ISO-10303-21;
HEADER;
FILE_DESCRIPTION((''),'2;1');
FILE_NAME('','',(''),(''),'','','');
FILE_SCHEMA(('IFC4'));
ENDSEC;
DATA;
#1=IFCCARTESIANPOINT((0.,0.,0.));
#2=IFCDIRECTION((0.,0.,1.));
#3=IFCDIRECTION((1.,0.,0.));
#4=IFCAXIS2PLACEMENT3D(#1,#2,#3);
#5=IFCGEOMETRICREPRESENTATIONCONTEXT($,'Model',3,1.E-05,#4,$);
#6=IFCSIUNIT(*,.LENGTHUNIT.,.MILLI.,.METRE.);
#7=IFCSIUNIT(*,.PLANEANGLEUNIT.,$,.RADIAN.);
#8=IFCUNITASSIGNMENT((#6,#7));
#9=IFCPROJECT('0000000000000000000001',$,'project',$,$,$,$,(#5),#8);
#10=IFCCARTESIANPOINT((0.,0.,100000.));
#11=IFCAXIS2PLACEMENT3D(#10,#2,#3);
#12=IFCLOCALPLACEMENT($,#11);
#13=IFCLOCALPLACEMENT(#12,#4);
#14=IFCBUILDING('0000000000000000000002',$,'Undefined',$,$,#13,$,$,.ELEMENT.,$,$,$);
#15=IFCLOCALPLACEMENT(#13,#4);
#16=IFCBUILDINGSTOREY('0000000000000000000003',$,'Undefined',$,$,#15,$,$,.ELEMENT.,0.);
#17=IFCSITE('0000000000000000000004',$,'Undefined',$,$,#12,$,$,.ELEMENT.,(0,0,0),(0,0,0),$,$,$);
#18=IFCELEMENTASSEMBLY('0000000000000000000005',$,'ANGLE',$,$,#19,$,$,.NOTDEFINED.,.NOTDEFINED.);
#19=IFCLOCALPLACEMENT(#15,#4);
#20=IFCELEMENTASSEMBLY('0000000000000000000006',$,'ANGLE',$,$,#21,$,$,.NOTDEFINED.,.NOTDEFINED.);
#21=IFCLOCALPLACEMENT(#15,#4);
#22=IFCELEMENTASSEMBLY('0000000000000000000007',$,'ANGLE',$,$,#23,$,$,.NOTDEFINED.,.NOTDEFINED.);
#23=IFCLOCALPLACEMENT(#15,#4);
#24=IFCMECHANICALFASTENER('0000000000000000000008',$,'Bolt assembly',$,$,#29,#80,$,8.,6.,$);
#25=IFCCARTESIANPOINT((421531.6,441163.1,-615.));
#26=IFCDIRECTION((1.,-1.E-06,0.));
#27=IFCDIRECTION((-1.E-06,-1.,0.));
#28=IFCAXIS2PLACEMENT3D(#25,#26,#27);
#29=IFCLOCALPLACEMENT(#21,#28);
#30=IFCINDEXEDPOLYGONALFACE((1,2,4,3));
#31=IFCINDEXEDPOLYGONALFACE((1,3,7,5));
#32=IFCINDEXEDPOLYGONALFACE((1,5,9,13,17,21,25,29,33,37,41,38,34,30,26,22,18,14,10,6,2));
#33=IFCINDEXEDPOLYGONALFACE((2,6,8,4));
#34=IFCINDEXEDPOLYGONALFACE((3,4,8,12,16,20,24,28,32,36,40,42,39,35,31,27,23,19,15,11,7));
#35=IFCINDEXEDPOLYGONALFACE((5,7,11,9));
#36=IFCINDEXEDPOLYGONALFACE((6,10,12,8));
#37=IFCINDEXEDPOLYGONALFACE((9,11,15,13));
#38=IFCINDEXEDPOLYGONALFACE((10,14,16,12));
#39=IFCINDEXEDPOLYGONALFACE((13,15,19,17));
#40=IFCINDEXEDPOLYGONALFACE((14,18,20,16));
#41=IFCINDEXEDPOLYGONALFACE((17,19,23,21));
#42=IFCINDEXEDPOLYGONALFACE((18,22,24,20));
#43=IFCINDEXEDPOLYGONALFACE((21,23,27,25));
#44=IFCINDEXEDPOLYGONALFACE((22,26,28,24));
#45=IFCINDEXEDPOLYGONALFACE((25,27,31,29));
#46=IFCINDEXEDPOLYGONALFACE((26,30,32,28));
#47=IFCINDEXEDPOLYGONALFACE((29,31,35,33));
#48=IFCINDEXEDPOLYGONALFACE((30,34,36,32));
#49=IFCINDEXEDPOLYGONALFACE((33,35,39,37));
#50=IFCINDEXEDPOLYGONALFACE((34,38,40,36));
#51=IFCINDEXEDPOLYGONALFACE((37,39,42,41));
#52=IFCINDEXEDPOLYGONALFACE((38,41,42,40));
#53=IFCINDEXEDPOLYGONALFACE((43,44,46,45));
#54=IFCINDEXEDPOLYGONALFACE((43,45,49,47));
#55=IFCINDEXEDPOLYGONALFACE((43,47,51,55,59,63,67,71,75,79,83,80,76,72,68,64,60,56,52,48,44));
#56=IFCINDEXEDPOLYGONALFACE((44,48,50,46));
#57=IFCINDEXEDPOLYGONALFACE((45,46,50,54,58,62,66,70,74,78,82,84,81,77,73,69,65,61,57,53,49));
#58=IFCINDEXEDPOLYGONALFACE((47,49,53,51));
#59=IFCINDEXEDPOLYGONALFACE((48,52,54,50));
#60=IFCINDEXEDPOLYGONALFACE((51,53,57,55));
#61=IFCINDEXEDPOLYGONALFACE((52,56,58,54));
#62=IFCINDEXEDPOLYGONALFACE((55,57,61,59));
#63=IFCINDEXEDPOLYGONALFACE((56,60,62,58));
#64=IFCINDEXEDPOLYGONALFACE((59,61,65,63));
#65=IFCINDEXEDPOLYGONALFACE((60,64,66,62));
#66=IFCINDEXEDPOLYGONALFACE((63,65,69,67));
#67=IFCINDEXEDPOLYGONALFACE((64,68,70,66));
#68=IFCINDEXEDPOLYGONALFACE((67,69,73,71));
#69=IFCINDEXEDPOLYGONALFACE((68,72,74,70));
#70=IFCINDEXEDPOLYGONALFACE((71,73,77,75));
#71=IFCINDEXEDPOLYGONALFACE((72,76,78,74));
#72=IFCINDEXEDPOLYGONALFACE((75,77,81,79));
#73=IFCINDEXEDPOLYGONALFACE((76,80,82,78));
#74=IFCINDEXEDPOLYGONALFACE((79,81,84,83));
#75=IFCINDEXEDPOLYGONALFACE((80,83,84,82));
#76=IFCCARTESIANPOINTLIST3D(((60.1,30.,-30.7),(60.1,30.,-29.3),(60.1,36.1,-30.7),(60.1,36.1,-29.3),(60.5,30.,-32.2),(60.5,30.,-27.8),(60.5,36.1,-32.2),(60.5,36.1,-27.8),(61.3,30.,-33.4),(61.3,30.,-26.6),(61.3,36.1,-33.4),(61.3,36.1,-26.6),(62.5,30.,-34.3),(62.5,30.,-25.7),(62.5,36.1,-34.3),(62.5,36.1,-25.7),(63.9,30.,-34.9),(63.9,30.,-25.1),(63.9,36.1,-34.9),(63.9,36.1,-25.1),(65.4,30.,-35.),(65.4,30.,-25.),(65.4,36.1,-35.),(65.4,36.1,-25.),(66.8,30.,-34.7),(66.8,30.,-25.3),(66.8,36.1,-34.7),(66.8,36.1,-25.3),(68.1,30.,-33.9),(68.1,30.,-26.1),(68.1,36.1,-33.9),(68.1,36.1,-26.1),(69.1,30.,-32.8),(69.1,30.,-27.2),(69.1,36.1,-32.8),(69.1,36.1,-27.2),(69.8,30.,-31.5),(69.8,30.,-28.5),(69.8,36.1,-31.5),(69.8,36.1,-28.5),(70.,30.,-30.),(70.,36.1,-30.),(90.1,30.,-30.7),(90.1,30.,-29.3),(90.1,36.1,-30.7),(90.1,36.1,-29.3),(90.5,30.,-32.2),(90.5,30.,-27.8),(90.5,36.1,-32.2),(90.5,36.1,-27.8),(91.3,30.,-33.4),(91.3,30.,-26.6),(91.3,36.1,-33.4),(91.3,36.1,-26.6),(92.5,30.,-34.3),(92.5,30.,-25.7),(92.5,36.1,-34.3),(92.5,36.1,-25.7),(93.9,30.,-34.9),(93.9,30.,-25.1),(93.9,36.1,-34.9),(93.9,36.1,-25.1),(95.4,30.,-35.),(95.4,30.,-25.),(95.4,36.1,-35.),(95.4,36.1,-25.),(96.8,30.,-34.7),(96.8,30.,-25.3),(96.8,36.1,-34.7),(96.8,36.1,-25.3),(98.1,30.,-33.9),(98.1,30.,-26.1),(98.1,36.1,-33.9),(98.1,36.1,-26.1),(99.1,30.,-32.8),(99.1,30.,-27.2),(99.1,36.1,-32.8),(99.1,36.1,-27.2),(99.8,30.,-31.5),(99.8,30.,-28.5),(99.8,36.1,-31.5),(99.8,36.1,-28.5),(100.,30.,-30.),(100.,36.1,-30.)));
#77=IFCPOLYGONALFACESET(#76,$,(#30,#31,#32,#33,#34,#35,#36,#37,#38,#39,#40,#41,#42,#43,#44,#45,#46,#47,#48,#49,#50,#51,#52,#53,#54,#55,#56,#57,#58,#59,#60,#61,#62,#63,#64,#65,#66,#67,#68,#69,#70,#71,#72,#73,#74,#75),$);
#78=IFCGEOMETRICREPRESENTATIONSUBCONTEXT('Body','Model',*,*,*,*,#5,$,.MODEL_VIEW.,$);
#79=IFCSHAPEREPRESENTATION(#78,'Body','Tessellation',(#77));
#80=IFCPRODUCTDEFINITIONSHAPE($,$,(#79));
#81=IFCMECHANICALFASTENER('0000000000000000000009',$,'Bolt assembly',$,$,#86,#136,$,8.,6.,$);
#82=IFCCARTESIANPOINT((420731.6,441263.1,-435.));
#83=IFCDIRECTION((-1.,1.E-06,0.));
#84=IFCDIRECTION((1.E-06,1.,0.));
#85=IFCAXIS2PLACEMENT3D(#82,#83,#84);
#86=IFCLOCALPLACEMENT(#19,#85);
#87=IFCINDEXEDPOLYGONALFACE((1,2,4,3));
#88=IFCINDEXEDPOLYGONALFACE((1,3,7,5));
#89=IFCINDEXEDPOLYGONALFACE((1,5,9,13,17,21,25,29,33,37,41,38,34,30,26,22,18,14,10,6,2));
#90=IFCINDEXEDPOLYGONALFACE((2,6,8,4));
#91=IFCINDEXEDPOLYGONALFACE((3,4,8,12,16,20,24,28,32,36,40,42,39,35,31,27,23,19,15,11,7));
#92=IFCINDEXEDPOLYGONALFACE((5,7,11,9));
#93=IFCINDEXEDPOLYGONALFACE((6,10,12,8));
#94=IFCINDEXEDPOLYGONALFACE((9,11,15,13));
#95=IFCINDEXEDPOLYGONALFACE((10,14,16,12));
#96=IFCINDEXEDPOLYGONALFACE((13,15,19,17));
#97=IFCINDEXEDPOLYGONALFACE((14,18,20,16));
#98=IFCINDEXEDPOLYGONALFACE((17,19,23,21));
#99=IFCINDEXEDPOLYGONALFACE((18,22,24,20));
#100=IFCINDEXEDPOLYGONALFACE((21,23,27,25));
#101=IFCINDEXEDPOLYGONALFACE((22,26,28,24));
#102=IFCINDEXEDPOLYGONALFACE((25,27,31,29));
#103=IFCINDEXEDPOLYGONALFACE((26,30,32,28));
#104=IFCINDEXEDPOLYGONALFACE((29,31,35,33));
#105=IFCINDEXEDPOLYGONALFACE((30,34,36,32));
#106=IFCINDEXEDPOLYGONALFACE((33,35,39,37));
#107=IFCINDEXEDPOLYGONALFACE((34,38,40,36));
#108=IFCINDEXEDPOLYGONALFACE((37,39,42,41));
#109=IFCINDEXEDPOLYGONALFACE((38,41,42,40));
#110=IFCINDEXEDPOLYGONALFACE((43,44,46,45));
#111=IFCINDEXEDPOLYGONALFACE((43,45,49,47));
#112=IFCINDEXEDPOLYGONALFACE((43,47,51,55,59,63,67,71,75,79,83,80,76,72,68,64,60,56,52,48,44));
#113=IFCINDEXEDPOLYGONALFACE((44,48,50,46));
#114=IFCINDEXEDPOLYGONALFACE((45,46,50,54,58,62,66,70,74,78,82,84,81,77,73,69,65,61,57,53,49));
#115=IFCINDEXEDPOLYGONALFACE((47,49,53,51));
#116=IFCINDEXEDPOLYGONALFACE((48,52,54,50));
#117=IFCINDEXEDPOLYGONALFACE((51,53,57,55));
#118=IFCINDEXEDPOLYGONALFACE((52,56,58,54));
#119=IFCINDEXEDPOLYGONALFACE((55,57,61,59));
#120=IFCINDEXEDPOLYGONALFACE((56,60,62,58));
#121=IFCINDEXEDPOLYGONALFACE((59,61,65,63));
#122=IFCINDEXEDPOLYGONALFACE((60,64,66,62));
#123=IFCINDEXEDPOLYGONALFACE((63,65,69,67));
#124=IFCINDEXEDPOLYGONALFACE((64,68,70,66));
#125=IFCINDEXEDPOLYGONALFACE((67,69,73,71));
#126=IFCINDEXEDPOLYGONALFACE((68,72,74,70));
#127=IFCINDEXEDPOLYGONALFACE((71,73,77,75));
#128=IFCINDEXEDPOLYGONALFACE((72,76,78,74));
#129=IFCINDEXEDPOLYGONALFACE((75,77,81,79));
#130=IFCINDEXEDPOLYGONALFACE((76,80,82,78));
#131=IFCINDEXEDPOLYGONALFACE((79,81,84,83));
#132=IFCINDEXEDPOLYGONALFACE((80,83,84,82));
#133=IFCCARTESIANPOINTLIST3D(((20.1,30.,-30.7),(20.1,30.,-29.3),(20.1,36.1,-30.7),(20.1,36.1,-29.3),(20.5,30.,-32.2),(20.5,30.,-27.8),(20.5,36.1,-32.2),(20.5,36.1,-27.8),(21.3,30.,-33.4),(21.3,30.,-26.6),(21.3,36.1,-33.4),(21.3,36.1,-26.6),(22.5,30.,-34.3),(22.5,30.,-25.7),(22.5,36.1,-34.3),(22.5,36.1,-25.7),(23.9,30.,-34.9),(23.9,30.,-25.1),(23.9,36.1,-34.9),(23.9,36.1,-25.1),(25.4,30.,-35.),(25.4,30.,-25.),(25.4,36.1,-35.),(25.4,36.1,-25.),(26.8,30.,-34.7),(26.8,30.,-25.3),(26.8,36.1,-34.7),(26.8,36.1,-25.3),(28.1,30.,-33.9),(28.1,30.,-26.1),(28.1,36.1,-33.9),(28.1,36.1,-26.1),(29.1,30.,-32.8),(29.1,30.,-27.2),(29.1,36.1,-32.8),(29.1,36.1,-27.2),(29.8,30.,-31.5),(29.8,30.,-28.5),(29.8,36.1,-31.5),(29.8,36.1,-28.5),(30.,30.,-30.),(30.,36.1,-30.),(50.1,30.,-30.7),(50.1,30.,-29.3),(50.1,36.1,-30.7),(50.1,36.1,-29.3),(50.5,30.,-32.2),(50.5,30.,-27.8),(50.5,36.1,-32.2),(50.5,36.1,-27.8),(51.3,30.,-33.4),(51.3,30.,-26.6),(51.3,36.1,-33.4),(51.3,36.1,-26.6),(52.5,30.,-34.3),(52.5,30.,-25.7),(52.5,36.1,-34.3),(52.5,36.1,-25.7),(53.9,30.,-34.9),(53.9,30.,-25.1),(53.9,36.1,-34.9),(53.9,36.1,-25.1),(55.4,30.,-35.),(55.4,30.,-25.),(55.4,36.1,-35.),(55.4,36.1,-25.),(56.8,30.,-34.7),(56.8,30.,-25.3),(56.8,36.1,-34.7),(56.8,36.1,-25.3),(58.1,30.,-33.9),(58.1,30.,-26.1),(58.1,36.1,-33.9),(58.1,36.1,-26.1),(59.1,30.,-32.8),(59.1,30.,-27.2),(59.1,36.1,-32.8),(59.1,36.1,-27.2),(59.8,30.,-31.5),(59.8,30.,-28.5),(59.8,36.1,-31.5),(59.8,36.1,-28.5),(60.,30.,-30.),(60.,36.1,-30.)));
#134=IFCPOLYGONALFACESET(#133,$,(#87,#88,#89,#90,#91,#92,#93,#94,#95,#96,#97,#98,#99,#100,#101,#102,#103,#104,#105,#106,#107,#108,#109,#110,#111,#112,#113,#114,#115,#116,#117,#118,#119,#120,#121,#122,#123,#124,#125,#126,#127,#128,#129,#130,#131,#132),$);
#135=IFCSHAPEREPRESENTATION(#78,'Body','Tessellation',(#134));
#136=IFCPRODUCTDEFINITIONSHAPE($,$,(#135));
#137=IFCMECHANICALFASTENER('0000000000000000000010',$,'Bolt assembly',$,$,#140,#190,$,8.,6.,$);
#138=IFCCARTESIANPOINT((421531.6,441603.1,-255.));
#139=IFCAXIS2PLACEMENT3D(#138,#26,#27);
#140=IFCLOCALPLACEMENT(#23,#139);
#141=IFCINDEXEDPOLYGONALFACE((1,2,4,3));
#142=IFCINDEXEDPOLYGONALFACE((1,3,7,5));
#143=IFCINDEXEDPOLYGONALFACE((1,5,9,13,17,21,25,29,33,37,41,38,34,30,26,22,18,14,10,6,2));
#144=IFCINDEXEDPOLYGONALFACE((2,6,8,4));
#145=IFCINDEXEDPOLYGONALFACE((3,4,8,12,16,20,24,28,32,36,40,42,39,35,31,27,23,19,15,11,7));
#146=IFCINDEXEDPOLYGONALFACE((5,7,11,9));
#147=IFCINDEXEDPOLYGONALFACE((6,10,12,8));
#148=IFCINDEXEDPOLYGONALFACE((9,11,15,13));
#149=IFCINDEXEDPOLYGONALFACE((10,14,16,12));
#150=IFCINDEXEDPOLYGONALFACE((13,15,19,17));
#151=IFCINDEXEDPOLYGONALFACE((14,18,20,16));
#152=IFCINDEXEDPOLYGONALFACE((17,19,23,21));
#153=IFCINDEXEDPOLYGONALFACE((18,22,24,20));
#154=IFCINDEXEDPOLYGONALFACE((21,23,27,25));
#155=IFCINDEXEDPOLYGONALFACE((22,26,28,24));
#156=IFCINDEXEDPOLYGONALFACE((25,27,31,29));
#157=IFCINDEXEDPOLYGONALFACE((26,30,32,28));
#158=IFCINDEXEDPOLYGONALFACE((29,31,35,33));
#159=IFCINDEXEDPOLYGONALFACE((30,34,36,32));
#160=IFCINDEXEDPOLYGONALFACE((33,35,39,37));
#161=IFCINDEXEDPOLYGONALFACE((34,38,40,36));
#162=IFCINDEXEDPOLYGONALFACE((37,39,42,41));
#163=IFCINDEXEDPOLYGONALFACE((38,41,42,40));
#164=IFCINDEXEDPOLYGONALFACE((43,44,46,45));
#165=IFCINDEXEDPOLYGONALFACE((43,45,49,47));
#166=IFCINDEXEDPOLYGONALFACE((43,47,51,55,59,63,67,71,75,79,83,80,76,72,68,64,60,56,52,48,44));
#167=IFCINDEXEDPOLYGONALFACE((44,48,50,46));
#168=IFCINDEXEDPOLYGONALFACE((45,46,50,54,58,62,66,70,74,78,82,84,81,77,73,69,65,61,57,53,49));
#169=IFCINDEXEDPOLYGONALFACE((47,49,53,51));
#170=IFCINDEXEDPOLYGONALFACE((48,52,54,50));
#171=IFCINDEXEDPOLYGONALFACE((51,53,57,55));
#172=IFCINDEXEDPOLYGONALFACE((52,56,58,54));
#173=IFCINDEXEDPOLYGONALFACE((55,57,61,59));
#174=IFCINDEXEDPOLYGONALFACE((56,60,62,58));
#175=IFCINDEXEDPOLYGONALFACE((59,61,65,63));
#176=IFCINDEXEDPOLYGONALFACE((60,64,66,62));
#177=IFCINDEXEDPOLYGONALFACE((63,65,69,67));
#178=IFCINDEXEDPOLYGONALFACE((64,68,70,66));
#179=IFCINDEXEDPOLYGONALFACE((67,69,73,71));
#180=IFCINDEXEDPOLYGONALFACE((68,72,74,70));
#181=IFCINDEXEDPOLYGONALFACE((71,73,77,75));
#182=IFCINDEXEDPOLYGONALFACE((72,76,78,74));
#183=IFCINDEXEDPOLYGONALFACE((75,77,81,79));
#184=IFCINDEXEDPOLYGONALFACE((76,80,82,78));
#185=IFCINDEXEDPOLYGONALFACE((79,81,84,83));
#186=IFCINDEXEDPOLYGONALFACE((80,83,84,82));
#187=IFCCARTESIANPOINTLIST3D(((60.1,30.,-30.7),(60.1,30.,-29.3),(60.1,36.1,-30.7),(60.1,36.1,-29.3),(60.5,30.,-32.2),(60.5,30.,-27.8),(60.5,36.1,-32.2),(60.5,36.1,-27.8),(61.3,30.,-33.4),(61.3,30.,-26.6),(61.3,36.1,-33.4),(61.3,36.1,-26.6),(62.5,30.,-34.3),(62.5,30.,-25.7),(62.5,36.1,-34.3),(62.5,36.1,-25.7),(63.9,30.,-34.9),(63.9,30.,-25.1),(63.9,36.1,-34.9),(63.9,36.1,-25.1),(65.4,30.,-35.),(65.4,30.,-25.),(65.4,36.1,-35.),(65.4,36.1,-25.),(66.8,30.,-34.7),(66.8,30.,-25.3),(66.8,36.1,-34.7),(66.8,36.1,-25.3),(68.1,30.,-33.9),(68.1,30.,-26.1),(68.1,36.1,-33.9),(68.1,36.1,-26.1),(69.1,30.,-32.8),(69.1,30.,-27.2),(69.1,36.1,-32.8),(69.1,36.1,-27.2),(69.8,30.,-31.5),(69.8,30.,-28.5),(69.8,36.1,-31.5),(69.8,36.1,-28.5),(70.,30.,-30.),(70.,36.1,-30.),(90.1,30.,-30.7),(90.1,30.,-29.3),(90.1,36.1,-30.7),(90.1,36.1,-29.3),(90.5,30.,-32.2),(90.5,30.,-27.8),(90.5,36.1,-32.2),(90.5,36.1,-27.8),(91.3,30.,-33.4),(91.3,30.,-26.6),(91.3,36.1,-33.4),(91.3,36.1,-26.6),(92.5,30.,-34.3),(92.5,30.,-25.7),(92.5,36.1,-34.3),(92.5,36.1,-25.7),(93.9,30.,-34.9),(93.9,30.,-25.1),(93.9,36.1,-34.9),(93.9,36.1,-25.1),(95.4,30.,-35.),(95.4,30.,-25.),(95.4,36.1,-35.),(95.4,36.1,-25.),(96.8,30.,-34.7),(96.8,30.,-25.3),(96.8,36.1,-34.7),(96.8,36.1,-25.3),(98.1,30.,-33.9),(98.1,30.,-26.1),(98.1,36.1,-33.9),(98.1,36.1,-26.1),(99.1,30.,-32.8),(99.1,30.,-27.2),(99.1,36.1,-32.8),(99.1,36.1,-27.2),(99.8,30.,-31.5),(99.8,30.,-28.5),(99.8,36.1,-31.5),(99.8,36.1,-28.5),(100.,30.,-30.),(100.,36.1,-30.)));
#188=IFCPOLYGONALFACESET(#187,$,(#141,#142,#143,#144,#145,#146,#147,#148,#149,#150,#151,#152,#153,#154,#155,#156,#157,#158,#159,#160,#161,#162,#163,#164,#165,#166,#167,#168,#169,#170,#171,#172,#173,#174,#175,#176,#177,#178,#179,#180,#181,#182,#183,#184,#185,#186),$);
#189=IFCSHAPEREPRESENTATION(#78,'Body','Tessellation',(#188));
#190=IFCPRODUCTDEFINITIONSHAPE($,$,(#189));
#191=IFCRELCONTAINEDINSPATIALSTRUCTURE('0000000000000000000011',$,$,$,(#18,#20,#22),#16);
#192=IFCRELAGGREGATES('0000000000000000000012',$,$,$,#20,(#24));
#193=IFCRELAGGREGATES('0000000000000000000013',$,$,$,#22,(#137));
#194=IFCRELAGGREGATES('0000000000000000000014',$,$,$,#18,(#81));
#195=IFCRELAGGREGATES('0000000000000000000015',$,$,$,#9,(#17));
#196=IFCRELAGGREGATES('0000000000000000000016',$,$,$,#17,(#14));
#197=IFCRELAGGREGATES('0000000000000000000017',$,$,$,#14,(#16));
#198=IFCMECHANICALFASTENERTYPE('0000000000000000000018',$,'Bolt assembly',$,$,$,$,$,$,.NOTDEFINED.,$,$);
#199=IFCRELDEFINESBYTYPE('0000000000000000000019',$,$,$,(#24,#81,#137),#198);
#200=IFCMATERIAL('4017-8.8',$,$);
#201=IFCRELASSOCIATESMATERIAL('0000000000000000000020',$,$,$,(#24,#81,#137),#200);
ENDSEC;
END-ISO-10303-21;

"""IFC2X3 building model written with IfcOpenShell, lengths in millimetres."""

from ifc_helpers import new_model, si_unit, frame, origin_with_axes, origin_2d_with_axis, place, context, subcontext, project, spatial, circle, extrude, source, transform, mapped, material, type_object, element, aggregate, save


model = new_model("IFC2X3")

# Units and contexts
model_context = context("Model", 3, precision=1e-05, world=origin_with_axes())
body_context = subcontext(model_context, "Body", "Model", "MODEL_VIEW")
ifc_project = project(units=[si_unit("LENGTHUNIT", "METRE", prefix="MILLI"), si_unit("PLANEANGLEUNIT", "RADIAN")], contexts=[model_context])

# Site, building, storey
site_placement = place(None, frame((0.0, 0.0, 100000.0), z_axis=(0.0, 0.0, 1.0), x_axis=(1.0, 0.0, 0.0)))
site = spatial("IfcSite", under=ifc_project, at=site_placement, Name="Undefined", CompositionType="ELEMENT", RefLatitude=(0, 0, 0), RefLongitude=(0, 0, 0))
building_placement = place(site_placement, origin_with_axes())
building = spatial("IfcBuilding", under=site, at=building_placement, Name="Undefined", CompositionType="ELEMENT")
storey_placement = place(building_placement, origin_with_axes())
storey = spatial("IfcBuildingStorey", under=building, at=storey_placement, Name="Undefined", CompositionType="ELEMENT", Elevation=0.0)

# Element assemblies
assembly_1_placement = place(storey_placement, origin_with_axes())
assembly_1 = element("IfcElementAssembly", 1, at=assembly_1_placement, inside=storey, Name="ANGLE", AssemblyPlace="NOTDEFINED", PredefinedType="NOTDEFINED")
assembly_2_placement = place(storey_placement, origin_with_axes())
assembly_2 = element("IfcElementAssembly", 2, at=assembly_2_placement, inside=storey, Name="ANGLE", AssemblyPlace="NOTDEFINED", PredefinedType="NOTDEFINED")
assembly_3_placement = place(storey_placement, origin_with_axes())
assembly_3 = element("IfcElementAssembly", 3, at=assembly_3_placement, inside=storey, Name="ANGLE", AssemblyPlace="NOTDEFINED", PredefinedType="NOTDEFINED")

# Mechanical fasteners
ifc_material_1 = material(Name="4017-8.8")
mechanical_fastener_type = type_object("IfcMechanicalFastenerType", Name="Bolt assembly")
shared_shape_1 = source(origin_with_axes(), body_context, "Body", "SweptSolid", [
    extrude(circle(Radius=5.0, at=origin_2d_with_axis()), frame((0.0, 30.0, 0.0), z_axis=(0.0, 1.0, 0.0), x_axis=(1.0, 0.0, 0.0)), (0.0, 0.0, 1.0), 6.1),
])
mechanical_fastener_1_placement = place(assembly_2_placement, frame((421531.6, 441163.1, -615.0), z_axis=(1.0, -0.000001, 0.0), x_axis=(-0.000001, -1.0, 0.0)))
mechanical_fastener_1 = element("IfcMechanicalFastener", 4, at=mechanical_fastener_1_placement, type_object=mechanical_fastener_type, material=ifc_material_1, Name="Bolt assembly", NominalDiameter=8.0, NominalLength=6.0, context=body_context, shape_type="MappedRepresentation", body=[
    mapped(shared_shape_1, transform((95.0, 0.0, -30.0))),
    mapped(shared_shape_1, transform((65.0, 0.0, -30.0))),
])
aggregate(assembly_2, [mechanical_fastener_1])
mechanical_fastener_2_placement = place(assembly_1_placement, frame((420731.6, 441263.1, -435.0), z_axis=(-1.0, 0.000001, 0.0), x_axis=(0.000001, 1.0, 0.0)))
mechanical_fastener_2 = element("IfcMechanicalFastener", 5, at=mechanical_fastener_2_placement, type_object=mechanical_fastener_type, material=ifc_material_1, Name="Bolt assembly", NominalDiameter=8.0, NominalLength=6.0, context=body_context, shape_type="MappedRepresentation", body=[
    mapped(shared_shape_1, transform((25.0, 0.0, -30.0))),
    mapped(shared_shape_1, transform((55.0, 0.0, -30.0))),
])
mechanical_fastener_3_placement = place(assembly_3_placement, frame((421531.6, 441603.1, -255.0), z_axis=(1.0, -0.000001, 0.0), x_axis=(-0.000001, -1.0, 0.0)))
mechanical_fastener_3 = element("IfcMechanicalFastener", 6, at=mechanical_fastener_3_placement, type_object=mechanical_fastener_type, material=ifc_material_1, Name="Bolt assembly", NominalDiameter=8.0, NominalLength=6.0, context=body_context, shape_type="MappedRepresentation", body=[
    mapped(shared_shape_1, transform((95.0, 0.0, -30.0))),
    mapped(shared_shape_1, transform((65.0, 0.0, -30.0))),
])
aggregate(assembly_3, [mechanical_fastener_3])
aggregate(assembly_1, [mechanical_fastener_2])

save(model, "model.ifc")
